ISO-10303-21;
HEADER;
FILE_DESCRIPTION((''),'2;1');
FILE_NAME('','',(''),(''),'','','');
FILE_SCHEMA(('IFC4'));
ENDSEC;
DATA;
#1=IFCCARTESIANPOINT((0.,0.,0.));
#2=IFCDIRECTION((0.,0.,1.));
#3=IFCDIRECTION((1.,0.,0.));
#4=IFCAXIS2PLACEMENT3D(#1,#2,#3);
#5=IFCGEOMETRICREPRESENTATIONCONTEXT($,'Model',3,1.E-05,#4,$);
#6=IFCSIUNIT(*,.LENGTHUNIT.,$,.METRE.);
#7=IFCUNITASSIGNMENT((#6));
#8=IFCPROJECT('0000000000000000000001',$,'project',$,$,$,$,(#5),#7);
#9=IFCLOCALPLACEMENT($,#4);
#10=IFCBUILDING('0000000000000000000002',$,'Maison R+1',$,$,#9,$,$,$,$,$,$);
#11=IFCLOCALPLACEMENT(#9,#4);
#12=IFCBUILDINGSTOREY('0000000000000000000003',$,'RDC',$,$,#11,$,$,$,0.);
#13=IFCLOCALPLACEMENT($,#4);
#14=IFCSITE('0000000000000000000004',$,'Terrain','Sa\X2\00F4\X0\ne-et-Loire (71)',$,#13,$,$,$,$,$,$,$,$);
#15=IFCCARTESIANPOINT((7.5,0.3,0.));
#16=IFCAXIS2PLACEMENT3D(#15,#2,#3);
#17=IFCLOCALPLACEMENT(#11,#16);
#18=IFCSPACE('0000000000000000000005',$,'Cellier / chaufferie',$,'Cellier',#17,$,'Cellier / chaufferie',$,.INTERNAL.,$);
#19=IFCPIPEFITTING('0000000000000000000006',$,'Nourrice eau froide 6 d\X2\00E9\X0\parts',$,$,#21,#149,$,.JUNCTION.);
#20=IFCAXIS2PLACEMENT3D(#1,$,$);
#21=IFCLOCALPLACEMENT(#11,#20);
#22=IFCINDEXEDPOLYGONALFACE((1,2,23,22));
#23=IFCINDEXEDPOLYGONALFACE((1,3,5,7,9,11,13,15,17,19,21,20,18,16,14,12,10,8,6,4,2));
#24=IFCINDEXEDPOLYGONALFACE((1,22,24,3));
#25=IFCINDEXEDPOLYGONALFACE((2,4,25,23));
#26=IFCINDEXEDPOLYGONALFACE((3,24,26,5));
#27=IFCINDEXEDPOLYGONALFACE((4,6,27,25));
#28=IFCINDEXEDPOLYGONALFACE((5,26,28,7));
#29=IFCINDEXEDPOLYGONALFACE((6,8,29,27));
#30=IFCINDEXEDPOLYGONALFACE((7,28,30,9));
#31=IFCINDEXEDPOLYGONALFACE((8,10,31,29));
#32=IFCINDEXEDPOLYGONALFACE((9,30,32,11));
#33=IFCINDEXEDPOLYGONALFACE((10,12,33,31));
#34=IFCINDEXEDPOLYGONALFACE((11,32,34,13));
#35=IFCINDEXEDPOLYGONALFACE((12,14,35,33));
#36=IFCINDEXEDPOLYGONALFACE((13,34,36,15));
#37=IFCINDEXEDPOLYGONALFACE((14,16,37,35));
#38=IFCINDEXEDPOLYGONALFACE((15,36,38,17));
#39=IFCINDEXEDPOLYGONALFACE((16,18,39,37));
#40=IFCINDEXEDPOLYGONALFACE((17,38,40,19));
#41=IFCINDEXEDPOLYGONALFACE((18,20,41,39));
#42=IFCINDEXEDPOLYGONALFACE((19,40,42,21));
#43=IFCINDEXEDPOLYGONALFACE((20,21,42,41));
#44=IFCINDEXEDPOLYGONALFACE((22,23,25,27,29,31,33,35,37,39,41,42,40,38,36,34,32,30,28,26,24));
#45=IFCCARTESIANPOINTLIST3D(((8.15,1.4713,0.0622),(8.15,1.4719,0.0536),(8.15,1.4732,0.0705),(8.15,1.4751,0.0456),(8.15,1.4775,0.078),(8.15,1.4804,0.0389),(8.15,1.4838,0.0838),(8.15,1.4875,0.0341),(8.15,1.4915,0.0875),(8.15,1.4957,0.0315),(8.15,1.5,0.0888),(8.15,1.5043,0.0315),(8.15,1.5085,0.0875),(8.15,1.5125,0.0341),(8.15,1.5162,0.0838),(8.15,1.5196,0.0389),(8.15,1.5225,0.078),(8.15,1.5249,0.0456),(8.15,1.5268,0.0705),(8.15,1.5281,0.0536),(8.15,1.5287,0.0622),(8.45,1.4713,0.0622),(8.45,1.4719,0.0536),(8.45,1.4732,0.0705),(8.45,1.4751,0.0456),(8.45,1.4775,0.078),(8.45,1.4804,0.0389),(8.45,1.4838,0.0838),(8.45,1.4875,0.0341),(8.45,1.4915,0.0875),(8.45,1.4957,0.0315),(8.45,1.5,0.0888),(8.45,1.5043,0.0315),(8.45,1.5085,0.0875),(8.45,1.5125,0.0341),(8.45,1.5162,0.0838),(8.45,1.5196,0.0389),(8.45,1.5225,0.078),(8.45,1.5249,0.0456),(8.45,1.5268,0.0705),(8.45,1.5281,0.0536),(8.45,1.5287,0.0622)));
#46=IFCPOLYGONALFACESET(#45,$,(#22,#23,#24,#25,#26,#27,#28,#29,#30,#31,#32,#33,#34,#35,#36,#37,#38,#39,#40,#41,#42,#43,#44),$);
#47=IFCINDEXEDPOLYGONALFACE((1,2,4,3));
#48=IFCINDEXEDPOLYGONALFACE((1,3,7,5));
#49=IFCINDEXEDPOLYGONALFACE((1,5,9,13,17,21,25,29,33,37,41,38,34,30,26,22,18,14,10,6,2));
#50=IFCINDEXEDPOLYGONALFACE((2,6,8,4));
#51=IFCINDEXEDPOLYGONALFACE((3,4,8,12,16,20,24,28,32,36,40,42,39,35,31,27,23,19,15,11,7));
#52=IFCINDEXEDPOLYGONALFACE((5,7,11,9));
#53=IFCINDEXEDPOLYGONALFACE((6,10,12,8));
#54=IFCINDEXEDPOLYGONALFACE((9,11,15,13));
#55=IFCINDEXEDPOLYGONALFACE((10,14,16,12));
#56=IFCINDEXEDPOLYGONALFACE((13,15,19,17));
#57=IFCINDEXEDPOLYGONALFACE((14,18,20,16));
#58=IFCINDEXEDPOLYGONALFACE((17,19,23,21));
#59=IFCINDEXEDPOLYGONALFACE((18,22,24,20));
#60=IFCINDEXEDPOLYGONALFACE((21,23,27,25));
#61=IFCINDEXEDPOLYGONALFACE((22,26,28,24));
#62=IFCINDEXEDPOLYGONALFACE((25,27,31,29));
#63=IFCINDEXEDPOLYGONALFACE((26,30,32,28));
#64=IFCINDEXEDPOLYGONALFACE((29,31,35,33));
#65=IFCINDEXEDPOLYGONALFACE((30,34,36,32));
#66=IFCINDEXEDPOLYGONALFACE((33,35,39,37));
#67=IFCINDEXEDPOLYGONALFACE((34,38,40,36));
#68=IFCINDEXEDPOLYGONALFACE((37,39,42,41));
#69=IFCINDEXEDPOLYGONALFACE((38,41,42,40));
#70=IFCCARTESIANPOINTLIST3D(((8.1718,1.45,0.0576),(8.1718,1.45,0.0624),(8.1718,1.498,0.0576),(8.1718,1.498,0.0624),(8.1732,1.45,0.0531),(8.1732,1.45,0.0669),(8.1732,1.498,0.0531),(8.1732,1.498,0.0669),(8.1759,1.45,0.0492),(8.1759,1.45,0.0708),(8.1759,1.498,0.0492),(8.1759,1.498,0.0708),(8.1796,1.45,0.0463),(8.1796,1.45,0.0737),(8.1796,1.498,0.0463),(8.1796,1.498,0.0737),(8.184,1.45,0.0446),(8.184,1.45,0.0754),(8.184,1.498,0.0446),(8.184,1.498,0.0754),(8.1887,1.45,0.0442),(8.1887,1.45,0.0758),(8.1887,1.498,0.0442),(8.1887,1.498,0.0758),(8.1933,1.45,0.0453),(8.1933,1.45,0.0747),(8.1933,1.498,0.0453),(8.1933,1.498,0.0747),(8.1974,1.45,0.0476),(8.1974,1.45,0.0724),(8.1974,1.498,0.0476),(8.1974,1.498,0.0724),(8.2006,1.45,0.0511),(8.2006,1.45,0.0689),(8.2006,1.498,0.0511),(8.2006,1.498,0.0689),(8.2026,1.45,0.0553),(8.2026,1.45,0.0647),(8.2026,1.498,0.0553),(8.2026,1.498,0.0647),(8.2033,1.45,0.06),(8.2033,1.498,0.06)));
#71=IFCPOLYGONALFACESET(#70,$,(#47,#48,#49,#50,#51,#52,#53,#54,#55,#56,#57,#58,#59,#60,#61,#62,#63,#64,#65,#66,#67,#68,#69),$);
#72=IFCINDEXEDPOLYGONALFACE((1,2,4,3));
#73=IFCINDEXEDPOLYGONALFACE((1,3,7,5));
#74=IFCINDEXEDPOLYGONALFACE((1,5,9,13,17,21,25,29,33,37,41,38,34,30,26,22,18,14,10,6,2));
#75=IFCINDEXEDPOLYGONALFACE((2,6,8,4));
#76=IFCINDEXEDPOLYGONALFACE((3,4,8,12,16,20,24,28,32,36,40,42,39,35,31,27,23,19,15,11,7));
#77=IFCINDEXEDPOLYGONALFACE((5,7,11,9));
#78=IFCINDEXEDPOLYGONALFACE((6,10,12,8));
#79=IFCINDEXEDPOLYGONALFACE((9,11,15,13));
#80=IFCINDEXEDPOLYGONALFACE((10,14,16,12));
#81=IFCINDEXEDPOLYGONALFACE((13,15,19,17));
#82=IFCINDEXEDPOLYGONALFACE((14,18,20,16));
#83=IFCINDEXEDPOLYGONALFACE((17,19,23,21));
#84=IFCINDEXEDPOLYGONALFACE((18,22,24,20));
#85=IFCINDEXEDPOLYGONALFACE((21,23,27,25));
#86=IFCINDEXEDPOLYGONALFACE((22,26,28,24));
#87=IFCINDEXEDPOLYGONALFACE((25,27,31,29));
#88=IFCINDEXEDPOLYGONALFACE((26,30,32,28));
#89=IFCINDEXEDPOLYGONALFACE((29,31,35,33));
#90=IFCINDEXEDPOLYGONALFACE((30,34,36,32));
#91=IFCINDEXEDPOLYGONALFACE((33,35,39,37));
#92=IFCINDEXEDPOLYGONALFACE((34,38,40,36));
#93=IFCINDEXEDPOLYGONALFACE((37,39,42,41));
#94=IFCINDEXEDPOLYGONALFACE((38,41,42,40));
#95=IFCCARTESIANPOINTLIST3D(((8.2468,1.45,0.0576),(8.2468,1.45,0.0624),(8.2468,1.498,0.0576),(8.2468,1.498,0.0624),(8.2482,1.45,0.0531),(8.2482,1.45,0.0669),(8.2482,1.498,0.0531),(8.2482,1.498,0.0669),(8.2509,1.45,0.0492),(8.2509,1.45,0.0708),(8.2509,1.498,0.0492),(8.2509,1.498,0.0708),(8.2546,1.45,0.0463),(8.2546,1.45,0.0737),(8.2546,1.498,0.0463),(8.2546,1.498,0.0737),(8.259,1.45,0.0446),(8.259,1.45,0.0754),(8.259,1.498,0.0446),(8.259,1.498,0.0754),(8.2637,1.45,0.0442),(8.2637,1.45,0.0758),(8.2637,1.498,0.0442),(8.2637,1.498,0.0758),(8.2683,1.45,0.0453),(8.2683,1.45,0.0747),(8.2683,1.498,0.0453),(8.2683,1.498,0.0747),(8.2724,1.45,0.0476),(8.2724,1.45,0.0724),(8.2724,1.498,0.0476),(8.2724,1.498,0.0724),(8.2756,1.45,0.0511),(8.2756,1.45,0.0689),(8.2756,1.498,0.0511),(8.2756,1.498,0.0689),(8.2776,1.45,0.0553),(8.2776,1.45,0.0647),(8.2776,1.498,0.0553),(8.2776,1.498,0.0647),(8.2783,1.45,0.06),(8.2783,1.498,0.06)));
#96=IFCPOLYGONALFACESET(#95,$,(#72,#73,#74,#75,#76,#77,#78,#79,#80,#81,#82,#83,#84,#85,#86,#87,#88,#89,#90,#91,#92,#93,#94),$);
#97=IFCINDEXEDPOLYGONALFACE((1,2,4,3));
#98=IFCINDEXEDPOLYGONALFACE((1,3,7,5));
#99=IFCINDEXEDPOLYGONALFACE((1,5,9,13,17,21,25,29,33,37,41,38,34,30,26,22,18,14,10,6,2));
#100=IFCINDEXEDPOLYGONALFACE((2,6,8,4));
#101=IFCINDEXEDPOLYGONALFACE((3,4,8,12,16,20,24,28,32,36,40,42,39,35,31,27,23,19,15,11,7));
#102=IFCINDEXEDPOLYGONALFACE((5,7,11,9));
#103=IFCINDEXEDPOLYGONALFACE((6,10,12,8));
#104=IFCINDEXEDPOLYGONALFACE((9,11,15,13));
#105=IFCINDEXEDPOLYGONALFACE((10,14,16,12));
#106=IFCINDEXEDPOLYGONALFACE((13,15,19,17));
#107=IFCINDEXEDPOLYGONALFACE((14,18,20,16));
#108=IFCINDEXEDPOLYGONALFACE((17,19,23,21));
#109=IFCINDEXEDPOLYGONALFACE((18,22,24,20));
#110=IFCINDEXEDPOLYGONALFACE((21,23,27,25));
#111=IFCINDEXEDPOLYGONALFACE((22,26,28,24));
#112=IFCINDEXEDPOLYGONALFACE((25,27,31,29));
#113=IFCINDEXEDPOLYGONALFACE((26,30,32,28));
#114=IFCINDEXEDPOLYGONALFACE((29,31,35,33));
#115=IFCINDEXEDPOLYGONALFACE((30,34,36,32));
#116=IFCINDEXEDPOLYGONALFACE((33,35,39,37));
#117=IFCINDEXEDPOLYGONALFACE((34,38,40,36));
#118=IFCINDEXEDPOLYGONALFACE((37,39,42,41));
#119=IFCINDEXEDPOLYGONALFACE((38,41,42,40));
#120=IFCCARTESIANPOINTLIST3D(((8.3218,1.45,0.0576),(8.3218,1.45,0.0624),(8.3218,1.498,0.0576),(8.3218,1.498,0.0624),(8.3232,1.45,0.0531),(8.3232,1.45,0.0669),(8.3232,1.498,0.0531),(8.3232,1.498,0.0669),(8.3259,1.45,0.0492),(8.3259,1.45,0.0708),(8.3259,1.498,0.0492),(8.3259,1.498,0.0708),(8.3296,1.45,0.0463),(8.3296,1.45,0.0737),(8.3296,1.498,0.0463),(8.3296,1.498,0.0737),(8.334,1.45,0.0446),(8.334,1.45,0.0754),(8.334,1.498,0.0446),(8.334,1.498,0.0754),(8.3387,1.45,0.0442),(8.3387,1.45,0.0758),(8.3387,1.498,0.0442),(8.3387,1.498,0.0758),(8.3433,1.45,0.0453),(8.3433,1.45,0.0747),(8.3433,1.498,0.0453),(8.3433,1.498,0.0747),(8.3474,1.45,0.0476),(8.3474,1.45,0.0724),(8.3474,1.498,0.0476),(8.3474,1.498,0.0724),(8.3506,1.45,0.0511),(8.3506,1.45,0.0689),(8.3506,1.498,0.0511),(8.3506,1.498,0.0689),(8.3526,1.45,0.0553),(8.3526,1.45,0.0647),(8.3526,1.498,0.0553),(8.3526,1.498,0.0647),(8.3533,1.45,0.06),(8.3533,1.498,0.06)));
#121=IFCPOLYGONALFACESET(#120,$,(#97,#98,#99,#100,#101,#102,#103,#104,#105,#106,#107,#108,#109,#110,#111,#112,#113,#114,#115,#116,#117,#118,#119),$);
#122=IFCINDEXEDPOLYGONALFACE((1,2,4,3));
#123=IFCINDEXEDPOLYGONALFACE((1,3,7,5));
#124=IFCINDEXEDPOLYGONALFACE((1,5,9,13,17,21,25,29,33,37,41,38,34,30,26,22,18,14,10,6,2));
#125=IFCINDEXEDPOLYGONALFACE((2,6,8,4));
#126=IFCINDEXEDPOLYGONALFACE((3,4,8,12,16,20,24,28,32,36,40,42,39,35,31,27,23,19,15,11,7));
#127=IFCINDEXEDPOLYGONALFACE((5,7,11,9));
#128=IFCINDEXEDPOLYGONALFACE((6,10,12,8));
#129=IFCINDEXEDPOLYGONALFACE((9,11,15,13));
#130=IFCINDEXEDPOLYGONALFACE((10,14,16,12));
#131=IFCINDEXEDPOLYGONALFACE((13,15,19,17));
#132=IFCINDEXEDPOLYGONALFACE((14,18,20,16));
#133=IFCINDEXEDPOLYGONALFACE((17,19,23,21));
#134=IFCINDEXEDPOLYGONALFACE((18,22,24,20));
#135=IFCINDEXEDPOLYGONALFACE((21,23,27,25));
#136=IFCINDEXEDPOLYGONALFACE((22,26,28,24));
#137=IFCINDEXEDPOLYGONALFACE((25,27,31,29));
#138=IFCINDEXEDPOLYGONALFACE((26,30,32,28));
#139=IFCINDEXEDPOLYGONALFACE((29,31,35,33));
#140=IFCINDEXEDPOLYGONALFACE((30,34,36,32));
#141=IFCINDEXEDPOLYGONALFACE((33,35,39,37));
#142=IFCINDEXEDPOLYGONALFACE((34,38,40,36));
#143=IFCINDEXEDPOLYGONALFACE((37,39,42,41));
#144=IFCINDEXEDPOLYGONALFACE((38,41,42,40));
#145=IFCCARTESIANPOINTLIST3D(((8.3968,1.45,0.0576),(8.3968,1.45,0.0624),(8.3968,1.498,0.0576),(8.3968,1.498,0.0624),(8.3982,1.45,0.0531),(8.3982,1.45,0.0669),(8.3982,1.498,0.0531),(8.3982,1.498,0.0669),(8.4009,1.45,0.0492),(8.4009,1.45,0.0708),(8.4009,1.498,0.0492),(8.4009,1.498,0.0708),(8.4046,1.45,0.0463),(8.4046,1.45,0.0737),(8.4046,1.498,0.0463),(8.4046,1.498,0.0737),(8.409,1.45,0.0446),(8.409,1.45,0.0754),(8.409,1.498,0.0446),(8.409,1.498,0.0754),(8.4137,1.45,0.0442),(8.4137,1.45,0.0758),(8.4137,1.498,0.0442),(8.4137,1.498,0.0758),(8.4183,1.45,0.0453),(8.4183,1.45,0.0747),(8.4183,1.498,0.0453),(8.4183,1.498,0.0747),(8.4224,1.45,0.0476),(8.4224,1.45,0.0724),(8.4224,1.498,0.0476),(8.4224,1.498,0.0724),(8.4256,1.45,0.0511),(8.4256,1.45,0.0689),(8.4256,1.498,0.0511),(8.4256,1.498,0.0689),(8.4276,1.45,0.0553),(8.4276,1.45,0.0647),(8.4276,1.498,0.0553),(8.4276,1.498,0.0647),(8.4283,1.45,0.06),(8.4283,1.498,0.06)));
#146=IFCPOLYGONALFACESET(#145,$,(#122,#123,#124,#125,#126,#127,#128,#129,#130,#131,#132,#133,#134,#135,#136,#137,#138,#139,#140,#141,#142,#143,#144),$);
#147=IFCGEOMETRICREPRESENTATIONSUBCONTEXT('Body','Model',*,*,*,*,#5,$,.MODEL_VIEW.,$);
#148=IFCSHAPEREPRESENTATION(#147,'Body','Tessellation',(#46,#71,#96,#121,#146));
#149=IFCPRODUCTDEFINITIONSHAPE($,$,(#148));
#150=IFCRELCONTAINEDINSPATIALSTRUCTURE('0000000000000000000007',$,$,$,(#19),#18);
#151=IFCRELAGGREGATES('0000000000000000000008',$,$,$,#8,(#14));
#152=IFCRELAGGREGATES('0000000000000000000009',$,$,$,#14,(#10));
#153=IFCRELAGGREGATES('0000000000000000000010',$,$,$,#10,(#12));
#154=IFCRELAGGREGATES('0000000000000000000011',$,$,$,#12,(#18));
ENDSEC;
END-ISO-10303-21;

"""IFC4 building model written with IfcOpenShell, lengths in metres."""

from ifc_helpers import new_model, si_unit, frame, origin_with_axes, place, context, subcontext, project, spatial, circle, extrude, element, save


model = new_model("IFC4")

# Units and contexts
model_context = context("Model", 3, precision=1e-05, world=origin_with_axes())
body_context = subcontext(model_context, "Body", "Model", "MODEL_VIEW")
ifc_project = project(units=[si_unit("LENGTHUNIT", "METRE")], contexts=[model_context])

# Site, building, storey
site_placement = place(None, origin_with_axes())
site = spatial("IfcSite", under=ifc_project, at=site_placement, Name="Terrain", Description="Saône-et-Loire (71)")
building_placement = place(None, origin_with_axes())
building = spatial("IfcBuilding", under=site, at=building_placement, Name="Maison R+1")
storey_placement = place(building_placement, origin_with_axes())
storey = spatial("IfcBuildingStorey", under=building, at=storey_placement, Name="RDC", Elevation=0.0)

# Shared definitions
space_placement = place(storey_placement, frame((7.5, 0.3, 0.0), z_axis=(0.0, 0.0, 1.0), x_axis=(1.0, 0.0, 0.0)))
space = spatial("IfcSpace", under=storey, at=space_placement, Name="Cellier / chaufferie", ObjectType="Cellier", LongName="Cellier / chaufferie", PredefinedType="INTERNAL")

# Pipe fitting
pipe_fitting_1_placement = place(space_placement, frame((0.65, 1.15, 0.02), z_axis=(0.0, 0.0, 1.0), x_axis=(1.0, 0.0, 0.0)))
element("IfcPipeFitting", 1, at=pipe_fitting_1_placement, inside=space, Name="Nourrice eau froide 6 départs", PredefinedType="JUNCTION", context=body_context, shape_type="SweptSolid", body=[
    extrude(circle(Radius=0.0288), frame((0.0, 0.05, 0.04), z_axis=(1.0, 0.0, 0.0), x_axis=(0.0, 0.0, 1.0)), (0.0, 0.0, 1.0), 0.3),
    extrude(circle(Radius=0.0158), frame((0.0375, 0.0, 0.04), z_axis=(0.0, 1.0, 0.0), x_axis=(1.0, 0.0, 0.0)), (0.0, 0.0, 1.0), 0.048),
    extrude(circle(Radius=0.0158), frame((0.1125, 0.0, 0.04), z_axis=(0.0, 1.0, 0.0), x_axis=(1.0, 0.0, 0.0)), (0.0, 0.0, 1.0), 0.048),
    extrude(circle(Radius=0.0158), frame((0.1875, 0.0, 0.04), z_axis=(0.0, 1.0, 0.0), x_axis=(1.0, 0.0, 0.0)), (0.0, 0.0, 1.0), 0.048),
    extrude(circle(Radius=0.0158), frame((0.2625, 0.0, 0.04), z_axis=(0.0, 1.0, 0.0), x_axis=(1.0, 0.0, 0.0)), (0.0, 0.0, 1.0), 0.048),
])

save(model, "model.ifc")
